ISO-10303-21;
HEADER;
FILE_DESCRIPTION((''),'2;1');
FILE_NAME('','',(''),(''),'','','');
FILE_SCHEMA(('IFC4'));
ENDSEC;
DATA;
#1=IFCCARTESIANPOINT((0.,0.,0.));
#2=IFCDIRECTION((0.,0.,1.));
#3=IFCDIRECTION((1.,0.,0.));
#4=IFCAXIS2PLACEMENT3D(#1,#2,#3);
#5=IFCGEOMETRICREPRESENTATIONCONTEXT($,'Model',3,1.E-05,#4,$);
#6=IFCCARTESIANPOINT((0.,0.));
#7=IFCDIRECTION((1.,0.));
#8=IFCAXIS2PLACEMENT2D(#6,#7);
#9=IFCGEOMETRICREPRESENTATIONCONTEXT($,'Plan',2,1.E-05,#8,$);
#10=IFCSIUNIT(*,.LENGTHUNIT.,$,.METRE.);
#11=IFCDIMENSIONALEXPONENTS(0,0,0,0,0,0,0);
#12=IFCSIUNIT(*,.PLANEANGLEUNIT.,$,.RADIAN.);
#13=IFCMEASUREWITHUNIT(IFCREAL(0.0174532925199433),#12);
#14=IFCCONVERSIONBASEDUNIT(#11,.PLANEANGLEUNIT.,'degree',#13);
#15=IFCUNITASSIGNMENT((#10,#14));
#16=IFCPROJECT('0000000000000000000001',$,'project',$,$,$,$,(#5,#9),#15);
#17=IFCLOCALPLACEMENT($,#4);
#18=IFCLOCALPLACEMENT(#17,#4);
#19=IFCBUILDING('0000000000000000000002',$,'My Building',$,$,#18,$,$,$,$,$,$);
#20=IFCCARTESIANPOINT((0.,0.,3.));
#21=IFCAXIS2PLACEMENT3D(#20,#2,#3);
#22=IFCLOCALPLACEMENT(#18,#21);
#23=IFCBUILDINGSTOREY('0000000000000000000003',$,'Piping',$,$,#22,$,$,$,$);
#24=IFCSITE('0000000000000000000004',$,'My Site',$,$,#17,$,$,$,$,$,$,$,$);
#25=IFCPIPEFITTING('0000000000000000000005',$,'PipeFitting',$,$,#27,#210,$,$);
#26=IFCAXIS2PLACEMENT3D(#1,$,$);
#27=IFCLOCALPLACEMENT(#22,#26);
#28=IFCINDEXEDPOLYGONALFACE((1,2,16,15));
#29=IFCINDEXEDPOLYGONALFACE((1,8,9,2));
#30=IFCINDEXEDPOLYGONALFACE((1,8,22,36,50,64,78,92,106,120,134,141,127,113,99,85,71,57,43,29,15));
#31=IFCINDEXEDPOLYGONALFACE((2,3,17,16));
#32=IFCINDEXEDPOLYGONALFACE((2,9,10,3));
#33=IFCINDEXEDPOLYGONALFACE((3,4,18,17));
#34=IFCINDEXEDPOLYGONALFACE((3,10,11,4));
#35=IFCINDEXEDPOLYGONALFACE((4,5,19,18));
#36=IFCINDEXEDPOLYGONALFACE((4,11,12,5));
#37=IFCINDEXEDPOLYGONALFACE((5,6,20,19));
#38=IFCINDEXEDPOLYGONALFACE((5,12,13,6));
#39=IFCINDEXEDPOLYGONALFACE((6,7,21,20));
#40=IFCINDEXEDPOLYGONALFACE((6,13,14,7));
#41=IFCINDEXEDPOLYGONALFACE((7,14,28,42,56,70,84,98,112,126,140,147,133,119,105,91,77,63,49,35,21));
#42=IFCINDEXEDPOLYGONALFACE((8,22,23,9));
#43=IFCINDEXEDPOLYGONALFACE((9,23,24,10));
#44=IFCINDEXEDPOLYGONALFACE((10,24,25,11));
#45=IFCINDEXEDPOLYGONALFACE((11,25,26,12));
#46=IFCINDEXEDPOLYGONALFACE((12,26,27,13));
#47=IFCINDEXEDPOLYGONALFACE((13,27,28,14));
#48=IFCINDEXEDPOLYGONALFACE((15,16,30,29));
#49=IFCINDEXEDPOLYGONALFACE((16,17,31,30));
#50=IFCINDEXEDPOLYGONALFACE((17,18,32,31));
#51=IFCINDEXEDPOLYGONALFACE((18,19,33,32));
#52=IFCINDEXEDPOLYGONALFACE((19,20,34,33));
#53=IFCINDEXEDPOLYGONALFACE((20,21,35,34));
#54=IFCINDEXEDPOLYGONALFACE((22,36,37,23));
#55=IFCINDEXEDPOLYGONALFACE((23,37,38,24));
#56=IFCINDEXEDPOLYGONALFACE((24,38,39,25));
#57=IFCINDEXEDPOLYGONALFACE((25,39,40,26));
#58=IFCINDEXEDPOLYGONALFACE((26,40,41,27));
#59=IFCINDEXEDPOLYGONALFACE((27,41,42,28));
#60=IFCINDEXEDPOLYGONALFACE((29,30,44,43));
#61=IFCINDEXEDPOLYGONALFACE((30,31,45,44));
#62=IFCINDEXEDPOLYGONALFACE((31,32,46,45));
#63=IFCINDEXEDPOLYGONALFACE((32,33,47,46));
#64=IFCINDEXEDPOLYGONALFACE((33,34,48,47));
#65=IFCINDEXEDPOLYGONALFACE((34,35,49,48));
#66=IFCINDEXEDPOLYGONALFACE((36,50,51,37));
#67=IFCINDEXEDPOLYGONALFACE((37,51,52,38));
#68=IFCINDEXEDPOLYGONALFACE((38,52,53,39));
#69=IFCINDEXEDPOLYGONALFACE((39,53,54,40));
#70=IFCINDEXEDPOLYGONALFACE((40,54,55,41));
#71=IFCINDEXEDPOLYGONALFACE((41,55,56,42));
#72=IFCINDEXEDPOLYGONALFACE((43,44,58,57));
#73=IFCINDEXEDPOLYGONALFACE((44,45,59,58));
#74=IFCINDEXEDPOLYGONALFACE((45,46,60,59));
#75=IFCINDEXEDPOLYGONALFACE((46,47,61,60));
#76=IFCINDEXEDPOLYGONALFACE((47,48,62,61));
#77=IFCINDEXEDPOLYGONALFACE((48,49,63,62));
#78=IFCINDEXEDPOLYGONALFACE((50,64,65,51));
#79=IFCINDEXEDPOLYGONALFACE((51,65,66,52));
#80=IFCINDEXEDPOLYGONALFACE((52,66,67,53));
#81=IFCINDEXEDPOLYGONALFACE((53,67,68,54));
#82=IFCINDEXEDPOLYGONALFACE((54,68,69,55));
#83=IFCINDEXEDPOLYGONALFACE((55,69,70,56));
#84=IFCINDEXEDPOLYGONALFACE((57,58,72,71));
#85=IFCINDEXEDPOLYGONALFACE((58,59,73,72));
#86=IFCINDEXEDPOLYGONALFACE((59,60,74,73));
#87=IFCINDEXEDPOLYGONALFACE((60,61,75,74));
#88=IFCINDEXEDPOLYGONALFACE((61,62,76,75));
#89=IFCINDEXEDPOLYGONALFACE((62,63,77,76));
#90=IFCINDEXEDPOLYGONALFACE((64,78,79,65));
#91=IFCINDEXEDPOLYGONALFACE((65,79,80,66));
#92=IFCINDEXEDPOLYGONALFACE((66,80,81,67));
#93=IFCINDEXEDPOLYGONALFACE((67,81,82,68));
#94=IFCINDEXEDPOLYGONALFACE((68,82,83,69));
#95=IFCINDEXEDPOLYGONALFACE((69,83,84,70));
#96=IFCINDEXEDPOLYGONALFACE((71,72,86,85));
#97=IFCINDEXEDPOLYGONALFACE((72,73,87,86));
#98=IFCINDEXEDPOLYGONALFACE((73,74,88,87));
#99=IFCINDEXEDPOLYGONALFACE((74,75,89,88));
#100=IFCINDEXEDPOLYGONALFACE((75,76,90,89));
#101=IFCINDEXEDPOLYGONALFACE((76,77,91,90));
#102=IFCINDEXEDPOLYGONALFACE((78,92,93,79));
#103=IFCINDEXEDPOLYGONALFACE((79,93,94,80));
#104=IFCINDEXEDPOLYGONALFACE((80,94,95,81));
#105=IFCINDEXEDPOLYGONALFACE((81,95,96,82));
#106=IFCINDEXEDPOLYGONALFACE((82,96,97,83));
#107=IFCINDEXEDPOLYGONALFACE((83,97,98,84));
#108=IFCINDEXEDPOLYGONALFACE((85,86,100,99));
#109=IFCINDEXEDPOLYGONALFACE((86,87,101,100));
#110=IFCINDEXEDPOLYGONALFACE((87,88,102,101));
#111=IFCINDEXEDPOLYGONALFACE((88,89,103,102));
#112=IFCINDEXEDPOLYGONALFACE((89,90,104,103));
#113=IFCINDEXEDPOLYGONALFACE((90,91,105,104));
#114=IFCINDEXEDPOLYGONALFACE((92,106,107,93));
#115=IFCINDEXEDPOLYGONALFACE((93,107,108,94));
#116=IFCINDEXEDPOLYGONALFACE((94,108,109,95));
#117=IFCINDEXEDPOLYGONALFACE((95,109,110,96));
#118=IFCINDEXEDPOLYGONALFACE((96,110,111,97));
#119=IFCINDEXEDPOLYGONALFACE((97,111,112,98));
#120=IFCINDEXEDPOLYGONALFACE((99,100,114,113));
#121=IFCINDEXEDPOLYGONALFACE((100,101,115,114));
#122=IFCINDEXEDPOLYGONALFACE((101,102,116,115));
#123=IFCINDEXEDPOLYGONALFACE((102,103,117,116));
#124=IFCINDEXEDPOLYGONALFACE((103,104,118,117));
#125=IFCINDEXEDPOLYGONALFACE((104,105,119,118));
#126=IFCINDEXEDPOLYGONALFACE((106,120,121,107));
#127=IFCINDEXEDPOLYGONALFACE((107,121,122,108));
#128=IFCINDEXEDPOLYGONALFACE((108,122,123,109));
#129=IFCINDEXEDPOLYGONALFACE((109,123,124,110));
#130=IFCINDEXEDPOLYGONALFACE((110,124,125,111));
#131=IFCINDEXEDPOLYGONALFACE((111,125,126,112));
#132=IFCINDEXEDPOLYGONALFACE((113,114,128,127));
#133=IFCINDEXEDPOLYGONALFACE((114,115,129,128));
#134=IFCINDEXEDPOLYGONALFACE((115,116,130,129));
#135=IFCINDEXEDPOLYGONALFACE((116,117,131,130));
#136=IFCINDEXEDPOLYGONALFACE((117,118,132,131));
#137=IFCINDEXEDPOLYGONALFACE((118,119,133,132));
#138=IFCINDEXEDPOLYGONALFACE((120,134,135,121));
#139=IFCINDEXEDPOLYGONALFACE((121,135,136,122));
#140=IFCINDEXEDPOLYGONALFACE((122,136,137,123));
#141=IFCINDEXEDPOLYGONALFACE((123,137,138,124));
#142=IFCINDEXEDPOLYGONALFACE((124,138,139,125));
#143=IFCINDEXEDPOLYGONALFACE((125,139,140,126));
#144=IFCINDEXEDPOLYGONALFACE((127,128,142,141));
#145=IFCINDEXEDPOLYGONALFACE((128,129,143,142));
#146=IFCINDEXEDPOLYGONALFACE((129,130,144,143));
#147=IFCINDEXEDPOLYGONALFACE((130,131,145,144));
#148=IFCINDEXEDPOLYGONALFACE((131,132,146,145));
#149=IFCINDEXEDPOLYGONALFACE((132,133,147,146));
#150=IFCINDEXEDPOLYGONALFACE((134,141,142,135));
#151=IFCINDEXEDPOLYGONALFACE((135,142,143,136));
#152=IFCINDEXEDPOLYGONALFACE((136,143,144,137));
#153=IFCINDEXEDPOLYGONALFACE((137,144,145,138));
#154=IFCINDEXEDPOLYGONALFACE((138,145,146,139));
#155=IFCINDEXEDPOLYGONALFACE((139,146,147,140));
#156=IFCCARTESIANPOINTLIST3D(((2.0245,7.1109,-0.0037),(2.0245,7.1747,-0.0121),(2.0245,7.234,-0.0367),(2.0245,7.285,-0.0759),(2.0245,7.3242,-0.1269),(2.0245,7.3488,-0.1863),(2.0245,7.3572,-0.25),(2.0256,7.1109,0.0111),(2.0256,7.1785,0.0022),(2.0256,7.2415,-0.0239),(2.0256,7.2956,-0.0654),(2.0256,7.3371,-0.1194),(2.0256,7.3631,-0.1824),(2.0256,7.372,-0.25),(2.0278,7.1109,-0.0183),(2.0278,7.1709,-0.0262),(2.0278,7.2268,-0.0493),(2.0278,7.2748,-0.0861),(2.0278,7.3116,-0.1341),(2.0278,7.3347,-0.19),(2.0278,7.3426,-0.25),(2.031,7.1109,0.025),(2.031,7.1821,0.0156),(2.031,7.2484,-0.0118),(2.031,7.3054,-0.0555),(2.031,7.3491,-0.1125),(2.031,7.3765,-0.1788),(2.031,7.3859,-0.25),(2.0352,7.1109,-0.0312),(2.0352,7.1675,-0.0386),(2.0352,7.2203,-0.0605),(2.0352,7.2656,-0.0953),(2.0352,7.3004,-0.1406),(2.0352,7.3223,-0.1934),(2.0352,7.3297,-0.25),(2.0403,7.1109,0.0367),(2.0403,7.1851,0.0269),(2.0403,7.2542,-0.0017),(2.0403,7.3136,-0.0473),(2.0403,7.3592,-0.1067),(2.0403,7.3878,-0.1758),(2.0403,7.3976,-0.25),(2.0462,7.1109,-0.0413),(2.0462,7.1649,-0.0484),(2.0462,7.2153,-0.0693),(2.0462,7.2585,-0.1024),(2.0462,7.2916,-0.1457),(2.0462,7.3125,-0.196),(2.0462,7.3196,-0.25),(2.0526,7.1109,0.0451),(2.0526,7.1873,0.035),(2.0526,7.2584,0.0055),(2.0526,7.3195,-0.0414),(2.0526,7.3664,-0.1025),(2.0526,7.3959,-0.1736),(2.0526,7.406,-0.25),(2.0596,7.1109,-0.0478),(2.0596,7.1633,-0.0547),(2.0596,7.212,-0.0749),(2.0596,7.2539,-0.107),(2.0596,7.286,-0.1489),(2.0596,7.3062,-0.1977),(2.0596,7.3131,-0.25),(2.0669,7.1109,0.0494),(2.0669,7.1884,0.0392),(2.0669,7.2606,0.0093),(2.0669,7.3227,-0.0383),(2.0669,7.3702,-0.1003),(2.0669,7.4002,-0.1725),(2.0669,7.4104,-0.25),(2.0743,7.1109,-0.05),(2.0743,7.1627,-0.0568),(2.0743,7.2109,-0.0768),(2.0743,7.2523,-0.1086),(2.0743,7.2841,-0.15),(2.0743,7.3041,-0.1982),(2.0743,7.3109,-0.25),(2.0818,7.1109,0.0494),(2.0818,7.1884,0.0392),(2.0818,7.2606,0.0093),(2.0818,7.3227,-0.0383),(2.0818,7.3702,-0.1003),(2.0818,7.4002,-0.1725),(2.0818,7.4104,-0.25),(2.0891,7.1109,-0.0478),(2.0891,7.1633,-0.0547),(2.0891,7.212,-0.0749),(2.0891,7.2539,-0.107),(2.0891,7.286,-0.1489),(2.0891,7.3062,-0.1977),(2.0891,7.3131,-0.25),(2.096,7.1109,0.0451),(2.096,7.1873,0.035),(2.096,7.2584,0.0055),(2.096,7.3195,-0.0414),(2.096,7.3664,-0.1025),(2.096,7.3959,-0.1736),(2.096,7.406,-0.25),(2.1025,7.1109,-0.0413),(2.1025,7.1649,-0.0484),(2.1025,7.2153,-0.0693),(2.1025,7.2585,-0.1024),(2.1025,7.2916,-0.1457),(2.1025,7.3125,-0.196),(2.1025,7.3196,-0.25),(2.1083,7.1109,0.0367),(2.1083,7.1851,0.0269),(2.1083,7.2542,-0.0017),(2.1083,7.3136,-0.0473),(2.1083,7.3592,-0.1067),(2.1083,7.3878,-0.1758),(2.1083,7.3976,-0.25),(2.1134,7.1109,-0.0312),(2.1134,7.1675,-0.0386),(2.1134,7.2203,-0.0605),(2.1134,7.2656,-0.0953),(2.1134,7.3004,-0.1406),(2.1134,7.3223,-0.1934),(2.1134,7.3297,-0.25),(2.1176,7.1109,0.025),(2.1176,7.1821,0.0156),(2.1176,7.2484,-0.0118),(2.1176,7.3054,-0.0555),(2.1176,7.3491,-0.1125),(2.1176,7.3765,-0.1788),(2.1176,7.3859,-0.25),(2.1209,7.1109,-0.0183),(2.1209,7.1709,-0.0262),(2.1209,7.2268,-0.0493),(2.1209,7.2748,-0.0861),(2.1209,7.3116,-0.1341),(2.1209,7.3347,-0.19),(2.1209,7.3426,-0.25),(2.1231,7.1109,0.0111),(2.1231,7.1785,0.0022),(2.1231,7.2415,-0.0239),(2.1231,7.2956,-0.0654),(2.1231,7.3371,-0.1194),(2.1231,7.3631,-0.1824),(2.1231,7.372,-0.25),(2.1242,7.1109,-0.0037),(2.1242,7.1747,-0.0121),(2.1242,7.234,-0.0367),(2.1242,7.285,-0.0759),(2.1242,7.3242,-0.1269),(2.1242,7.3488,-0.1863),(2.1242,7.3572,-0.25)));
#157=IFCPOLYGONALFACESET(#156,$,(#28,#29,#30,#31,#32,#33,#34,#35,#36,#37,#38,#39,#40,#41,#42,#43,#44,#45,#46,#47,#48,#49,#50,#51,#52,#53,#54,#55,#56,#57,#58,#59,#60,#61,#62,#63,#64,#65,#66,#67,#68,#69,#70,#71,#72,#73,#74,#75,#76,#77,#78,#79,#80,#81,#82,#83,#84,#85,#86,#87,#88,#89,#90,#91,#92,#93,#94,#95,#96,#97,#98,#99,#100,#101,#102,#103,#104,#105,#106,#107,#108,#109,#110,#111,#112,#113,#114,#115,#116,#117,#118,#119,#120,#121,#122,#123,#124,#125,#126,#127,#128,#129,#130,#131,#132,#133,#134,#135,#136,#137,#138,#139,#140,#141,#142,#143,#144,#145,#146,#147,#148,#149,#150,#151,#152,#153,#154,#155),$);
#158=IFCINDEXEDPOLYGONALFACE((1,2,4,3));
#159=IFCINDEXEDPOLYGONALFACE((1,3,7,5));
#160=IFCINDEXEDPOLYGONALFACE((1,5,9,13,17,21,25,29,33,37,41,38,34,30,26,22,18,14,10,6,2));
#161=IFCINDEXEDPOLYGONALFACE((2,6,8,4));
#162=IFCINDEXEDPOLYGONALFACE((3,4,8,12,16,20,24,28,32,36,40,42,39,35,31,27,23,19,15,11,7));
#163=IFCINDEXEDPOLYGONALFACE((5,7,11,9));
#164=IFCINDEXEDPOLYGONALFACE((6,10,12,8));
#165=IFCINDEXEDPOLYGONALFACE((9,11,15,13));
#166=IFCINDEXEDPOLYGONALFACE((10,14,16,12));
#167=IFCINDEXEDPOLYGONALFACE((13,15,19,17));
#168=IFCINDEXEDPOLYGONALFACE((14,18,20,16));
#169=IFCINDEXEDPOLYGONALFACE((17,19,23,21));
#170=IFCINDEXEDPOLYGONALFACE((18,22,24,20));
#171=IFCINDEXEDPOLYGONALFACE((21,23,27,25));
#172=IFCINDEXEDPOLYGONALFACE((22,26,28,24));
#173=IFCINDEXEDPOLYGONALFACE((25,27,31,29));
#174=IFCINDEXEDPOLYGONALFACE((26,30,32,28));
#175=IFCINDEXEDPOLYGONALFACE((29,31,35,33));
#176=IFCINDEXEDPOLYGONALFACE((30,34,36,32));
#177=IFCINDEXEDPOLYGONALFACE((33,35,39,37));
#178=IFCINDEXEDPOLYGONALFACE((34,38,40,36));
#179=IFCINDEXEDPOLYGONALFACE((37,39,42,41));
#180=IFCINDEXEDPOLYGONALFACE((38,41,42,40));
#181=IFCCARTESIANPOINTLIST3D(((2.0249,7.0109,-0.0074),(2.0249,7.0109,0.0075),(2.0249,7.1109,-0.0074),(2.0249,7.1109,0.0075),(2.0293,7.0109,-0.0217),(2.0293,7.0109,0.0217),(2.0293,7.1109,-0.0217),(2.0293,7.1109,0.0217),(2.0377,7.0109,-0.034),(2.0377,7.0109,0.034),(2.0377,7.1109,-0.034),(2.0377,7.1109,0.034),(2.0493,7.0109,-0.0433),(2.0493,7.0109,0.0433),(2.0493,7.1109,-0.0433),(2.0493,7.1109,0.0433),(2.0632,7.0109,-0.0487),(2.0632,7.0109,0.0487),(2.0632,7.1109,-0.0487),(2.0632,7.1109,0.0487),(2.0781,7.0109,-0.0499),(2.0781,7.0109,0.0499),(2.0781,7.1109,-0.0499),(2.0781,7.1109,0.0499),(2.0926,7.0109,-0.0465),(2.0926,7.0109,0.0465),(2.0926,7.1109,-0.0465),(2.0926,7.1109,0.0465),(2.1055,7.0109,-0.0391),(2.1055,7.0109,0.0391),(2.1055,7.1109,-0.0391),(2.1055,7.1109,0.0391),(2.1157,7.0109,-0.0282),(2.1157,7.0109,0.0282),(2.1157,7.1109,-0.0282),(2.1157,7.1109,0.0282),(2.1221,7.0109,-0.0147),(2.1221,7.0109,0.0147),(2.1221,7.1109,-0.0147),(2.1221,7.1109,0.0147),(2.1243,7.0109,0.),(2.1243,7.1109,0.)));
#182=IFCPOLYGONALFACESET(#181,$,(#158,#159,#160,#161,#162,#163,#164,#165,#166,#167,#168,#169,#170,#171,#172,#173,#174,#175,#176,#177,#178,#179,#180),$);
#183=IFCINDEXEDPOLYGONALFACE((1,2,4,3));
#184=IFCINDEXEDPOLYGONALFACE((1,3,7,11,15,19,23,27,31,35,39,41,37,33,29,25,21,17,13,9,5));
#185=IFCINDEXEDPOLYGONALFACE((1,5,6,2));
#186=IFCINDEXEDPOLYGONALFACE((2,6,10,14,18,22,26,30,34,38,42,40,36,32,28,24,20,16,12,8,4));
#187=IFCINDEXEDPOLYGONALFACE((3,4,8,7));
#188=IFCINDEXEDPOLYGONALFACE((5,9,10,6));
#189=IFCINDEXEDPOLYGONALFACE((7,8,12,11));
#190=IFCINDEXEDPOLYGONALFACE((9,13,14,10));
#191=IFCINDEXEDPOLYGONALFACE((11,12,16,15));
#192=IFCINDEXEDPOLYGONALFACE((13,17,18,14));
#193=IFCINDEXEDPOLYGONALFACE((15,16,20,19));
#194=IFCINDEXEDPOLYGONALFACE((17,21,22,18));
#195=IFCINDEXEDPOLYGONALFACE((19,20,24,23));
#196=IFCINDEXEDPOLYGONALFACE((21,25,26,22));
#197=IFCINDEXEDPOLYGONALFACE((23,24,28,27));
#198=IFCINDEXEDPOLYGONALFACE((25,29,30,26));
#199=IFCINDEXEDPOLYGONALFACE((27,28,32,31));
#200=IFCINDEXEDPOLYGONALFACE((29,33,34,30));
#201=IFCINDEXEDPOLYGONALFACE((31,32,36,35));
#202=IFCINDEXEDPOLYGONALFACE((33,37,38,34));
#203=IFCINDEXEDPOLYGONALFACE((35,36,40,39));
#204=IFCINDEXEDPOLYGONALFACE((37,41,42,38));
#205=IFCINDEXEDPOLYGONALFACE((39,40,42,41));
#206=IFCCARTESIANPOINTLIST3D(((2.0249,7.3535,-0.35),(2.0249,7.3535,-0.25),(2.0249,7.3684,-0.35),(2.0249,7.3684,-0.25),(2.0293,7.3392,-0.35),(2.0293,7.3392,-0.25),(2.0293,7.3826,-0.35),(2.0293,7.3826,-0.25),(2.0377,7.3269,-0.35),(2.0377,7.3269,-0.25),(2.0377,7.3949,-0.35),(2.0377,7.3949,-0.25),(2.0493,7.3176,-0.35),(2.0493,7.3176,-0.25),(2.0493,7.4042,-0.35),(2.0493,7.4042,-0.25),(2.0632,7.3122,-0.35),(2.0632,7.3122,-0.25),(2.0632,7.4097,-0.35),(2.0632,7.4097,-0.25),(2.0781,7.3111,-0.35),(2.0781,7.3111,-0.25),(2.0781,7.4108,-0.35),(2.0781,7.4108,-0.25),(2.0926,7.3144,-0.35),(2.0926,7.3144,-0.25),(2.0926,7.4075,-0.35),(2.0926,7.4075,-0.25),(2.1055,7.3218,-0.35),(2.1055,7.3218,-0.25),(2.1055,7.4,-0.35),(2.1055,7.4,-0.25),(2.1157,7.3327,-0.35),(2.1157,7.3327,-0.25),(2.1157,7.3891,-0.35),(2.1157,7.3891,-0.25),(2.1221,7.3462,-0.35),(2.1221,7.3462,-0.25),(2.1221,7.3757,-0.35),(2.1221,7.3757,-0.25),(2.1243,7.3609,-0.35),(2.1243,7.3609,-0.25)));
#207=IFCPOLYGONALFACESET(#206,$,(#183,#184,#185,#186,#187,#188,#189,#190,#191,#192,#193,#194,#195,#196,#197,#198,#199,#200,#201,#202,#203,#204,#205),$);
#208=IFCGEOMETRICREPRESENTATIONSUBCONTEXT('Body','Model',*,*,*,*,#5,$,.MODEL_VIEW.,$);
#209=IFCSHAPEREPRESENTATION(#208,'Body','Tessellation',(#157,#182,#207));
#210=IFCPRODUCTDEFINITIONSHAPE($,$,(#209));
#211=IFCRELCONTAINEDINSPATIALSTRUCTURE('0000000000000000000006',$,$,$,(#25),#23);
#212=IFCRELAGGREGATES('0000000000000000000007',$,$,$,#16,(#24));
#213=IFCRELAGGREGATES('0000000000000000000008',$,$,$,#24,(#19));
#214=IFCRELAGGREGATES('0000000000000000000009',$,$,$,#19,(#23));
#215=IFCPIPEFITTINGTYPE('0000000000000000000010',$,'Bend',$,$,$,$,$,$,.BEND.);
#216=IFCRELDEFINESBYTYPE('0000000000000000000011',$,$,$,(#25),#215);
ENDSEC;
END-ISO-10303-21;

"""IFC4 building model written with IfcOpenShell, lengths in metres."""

from ifc_helpers import new_model, entity, si_unit, converted_unit, frame, origin_with_axes, origin_2d_with_axis, place, context, subcontext, project, spatial, circle, extrude, source, transform, mapped, type_object, type_shapes, element, save


model = new_model("IFC4")

# Units and contexts
model_context = context("Model", 3, precision=1e-05, world=origin_with_axes())
plan_context = context("Plan", 2, precision=1e-05, world=origin_2d_with_axis())
body_context = subcontext(model_context, "Body", "Model", "MODEL_VIEW")
ifc_project = project(units=[si_unit("LENGTHUNIT", "METRE"), converted_unit("PLANEANGLEUNIT", "degree", entity("IfcReal", 0.0174532925199433), si_unit("PLANEANGLEUNIT", "RADIAN"), dimensions=[0, 0, 0, 0, 0, 0, 0])], contexts=[model_context, plan_context])

# Site, building, storey
site_placement = place(None, origin_with_axes())
site = spatial("IfcSite", under=ifc_project, at=site_placement, Name="My Site")
building_placement = place(site_placement, origin_with_axes())
building = spatial("IfcBuilding", under=site, at=building_placement, Name="My Building")
storey_placement = place(building_placement, frame((0.0, 0.0, 3.0), z_axis=(0.0, 0.0, 1.0), x_axis=(1.0, 0.0, 0.0)))
storey = spatial("IfcBuildingStorey", under=building, at=storey_placement, Name="Piping")

# Pipe fitting
pipe_fitting_type = type_object("IfcPipeFittingType", Name="Bend", PredefinedType="BEND")
shared_shape = source(origin_with_axes(), body_context, "Body", "SolidModel", [
    entity("IfcSweptDiskSolid", entity("IfcIndexedPolyCurve", entity("IfcCartesianPointList3D", [[0.0, 0.0, -0.1], [0.0, -0.0732, -0.2768], [0.0, -0.25, -0.35]]), [entity("IfcArcIndex", [1, 2, 3])]), 0.05),
    extrude(circle(Radius=0.05), origin_with_axes(), (0.0, 0.0, -1.0), 0.1),
    extrude(circle(Radius=0.05), frame((0.0, -0.25, -0.35), z_axis=(0.0, -1.0, 0.0), x_axis=(1.0, 0.0, 0.0)), (0.0, 0.0, 1.0), 0.1),
])
type_shapes(pipe_fitting_type, [shared_shape])
for number, where, z_axis, x_axis, name in (
    (1, (2.0743, 7.0109, 0.0), (0.0, -1.0, 0.0), (1.0, 0.0, 0.0), "PipeFitting"),
):
    element("IfcPipeFitting", number, at=place(storey_placement, frame(where, z_axis=z_axis, x_axis=x_axis)), inside=storey, type_object=pipe_fitting_type, Name=name, context=body_context, shape_type="MappedRepresentation", body=[
        mapped(shared_shape, transform((0.0, 0.0, 0.0), x_axis=(1.0, 0.0, 0.0), y_axis=(0.0, 1.0, 0.0), z_axis=(0.0, 0.0, 1.0), scale=1.0)),
    ])

save(model, "model.ifc")
